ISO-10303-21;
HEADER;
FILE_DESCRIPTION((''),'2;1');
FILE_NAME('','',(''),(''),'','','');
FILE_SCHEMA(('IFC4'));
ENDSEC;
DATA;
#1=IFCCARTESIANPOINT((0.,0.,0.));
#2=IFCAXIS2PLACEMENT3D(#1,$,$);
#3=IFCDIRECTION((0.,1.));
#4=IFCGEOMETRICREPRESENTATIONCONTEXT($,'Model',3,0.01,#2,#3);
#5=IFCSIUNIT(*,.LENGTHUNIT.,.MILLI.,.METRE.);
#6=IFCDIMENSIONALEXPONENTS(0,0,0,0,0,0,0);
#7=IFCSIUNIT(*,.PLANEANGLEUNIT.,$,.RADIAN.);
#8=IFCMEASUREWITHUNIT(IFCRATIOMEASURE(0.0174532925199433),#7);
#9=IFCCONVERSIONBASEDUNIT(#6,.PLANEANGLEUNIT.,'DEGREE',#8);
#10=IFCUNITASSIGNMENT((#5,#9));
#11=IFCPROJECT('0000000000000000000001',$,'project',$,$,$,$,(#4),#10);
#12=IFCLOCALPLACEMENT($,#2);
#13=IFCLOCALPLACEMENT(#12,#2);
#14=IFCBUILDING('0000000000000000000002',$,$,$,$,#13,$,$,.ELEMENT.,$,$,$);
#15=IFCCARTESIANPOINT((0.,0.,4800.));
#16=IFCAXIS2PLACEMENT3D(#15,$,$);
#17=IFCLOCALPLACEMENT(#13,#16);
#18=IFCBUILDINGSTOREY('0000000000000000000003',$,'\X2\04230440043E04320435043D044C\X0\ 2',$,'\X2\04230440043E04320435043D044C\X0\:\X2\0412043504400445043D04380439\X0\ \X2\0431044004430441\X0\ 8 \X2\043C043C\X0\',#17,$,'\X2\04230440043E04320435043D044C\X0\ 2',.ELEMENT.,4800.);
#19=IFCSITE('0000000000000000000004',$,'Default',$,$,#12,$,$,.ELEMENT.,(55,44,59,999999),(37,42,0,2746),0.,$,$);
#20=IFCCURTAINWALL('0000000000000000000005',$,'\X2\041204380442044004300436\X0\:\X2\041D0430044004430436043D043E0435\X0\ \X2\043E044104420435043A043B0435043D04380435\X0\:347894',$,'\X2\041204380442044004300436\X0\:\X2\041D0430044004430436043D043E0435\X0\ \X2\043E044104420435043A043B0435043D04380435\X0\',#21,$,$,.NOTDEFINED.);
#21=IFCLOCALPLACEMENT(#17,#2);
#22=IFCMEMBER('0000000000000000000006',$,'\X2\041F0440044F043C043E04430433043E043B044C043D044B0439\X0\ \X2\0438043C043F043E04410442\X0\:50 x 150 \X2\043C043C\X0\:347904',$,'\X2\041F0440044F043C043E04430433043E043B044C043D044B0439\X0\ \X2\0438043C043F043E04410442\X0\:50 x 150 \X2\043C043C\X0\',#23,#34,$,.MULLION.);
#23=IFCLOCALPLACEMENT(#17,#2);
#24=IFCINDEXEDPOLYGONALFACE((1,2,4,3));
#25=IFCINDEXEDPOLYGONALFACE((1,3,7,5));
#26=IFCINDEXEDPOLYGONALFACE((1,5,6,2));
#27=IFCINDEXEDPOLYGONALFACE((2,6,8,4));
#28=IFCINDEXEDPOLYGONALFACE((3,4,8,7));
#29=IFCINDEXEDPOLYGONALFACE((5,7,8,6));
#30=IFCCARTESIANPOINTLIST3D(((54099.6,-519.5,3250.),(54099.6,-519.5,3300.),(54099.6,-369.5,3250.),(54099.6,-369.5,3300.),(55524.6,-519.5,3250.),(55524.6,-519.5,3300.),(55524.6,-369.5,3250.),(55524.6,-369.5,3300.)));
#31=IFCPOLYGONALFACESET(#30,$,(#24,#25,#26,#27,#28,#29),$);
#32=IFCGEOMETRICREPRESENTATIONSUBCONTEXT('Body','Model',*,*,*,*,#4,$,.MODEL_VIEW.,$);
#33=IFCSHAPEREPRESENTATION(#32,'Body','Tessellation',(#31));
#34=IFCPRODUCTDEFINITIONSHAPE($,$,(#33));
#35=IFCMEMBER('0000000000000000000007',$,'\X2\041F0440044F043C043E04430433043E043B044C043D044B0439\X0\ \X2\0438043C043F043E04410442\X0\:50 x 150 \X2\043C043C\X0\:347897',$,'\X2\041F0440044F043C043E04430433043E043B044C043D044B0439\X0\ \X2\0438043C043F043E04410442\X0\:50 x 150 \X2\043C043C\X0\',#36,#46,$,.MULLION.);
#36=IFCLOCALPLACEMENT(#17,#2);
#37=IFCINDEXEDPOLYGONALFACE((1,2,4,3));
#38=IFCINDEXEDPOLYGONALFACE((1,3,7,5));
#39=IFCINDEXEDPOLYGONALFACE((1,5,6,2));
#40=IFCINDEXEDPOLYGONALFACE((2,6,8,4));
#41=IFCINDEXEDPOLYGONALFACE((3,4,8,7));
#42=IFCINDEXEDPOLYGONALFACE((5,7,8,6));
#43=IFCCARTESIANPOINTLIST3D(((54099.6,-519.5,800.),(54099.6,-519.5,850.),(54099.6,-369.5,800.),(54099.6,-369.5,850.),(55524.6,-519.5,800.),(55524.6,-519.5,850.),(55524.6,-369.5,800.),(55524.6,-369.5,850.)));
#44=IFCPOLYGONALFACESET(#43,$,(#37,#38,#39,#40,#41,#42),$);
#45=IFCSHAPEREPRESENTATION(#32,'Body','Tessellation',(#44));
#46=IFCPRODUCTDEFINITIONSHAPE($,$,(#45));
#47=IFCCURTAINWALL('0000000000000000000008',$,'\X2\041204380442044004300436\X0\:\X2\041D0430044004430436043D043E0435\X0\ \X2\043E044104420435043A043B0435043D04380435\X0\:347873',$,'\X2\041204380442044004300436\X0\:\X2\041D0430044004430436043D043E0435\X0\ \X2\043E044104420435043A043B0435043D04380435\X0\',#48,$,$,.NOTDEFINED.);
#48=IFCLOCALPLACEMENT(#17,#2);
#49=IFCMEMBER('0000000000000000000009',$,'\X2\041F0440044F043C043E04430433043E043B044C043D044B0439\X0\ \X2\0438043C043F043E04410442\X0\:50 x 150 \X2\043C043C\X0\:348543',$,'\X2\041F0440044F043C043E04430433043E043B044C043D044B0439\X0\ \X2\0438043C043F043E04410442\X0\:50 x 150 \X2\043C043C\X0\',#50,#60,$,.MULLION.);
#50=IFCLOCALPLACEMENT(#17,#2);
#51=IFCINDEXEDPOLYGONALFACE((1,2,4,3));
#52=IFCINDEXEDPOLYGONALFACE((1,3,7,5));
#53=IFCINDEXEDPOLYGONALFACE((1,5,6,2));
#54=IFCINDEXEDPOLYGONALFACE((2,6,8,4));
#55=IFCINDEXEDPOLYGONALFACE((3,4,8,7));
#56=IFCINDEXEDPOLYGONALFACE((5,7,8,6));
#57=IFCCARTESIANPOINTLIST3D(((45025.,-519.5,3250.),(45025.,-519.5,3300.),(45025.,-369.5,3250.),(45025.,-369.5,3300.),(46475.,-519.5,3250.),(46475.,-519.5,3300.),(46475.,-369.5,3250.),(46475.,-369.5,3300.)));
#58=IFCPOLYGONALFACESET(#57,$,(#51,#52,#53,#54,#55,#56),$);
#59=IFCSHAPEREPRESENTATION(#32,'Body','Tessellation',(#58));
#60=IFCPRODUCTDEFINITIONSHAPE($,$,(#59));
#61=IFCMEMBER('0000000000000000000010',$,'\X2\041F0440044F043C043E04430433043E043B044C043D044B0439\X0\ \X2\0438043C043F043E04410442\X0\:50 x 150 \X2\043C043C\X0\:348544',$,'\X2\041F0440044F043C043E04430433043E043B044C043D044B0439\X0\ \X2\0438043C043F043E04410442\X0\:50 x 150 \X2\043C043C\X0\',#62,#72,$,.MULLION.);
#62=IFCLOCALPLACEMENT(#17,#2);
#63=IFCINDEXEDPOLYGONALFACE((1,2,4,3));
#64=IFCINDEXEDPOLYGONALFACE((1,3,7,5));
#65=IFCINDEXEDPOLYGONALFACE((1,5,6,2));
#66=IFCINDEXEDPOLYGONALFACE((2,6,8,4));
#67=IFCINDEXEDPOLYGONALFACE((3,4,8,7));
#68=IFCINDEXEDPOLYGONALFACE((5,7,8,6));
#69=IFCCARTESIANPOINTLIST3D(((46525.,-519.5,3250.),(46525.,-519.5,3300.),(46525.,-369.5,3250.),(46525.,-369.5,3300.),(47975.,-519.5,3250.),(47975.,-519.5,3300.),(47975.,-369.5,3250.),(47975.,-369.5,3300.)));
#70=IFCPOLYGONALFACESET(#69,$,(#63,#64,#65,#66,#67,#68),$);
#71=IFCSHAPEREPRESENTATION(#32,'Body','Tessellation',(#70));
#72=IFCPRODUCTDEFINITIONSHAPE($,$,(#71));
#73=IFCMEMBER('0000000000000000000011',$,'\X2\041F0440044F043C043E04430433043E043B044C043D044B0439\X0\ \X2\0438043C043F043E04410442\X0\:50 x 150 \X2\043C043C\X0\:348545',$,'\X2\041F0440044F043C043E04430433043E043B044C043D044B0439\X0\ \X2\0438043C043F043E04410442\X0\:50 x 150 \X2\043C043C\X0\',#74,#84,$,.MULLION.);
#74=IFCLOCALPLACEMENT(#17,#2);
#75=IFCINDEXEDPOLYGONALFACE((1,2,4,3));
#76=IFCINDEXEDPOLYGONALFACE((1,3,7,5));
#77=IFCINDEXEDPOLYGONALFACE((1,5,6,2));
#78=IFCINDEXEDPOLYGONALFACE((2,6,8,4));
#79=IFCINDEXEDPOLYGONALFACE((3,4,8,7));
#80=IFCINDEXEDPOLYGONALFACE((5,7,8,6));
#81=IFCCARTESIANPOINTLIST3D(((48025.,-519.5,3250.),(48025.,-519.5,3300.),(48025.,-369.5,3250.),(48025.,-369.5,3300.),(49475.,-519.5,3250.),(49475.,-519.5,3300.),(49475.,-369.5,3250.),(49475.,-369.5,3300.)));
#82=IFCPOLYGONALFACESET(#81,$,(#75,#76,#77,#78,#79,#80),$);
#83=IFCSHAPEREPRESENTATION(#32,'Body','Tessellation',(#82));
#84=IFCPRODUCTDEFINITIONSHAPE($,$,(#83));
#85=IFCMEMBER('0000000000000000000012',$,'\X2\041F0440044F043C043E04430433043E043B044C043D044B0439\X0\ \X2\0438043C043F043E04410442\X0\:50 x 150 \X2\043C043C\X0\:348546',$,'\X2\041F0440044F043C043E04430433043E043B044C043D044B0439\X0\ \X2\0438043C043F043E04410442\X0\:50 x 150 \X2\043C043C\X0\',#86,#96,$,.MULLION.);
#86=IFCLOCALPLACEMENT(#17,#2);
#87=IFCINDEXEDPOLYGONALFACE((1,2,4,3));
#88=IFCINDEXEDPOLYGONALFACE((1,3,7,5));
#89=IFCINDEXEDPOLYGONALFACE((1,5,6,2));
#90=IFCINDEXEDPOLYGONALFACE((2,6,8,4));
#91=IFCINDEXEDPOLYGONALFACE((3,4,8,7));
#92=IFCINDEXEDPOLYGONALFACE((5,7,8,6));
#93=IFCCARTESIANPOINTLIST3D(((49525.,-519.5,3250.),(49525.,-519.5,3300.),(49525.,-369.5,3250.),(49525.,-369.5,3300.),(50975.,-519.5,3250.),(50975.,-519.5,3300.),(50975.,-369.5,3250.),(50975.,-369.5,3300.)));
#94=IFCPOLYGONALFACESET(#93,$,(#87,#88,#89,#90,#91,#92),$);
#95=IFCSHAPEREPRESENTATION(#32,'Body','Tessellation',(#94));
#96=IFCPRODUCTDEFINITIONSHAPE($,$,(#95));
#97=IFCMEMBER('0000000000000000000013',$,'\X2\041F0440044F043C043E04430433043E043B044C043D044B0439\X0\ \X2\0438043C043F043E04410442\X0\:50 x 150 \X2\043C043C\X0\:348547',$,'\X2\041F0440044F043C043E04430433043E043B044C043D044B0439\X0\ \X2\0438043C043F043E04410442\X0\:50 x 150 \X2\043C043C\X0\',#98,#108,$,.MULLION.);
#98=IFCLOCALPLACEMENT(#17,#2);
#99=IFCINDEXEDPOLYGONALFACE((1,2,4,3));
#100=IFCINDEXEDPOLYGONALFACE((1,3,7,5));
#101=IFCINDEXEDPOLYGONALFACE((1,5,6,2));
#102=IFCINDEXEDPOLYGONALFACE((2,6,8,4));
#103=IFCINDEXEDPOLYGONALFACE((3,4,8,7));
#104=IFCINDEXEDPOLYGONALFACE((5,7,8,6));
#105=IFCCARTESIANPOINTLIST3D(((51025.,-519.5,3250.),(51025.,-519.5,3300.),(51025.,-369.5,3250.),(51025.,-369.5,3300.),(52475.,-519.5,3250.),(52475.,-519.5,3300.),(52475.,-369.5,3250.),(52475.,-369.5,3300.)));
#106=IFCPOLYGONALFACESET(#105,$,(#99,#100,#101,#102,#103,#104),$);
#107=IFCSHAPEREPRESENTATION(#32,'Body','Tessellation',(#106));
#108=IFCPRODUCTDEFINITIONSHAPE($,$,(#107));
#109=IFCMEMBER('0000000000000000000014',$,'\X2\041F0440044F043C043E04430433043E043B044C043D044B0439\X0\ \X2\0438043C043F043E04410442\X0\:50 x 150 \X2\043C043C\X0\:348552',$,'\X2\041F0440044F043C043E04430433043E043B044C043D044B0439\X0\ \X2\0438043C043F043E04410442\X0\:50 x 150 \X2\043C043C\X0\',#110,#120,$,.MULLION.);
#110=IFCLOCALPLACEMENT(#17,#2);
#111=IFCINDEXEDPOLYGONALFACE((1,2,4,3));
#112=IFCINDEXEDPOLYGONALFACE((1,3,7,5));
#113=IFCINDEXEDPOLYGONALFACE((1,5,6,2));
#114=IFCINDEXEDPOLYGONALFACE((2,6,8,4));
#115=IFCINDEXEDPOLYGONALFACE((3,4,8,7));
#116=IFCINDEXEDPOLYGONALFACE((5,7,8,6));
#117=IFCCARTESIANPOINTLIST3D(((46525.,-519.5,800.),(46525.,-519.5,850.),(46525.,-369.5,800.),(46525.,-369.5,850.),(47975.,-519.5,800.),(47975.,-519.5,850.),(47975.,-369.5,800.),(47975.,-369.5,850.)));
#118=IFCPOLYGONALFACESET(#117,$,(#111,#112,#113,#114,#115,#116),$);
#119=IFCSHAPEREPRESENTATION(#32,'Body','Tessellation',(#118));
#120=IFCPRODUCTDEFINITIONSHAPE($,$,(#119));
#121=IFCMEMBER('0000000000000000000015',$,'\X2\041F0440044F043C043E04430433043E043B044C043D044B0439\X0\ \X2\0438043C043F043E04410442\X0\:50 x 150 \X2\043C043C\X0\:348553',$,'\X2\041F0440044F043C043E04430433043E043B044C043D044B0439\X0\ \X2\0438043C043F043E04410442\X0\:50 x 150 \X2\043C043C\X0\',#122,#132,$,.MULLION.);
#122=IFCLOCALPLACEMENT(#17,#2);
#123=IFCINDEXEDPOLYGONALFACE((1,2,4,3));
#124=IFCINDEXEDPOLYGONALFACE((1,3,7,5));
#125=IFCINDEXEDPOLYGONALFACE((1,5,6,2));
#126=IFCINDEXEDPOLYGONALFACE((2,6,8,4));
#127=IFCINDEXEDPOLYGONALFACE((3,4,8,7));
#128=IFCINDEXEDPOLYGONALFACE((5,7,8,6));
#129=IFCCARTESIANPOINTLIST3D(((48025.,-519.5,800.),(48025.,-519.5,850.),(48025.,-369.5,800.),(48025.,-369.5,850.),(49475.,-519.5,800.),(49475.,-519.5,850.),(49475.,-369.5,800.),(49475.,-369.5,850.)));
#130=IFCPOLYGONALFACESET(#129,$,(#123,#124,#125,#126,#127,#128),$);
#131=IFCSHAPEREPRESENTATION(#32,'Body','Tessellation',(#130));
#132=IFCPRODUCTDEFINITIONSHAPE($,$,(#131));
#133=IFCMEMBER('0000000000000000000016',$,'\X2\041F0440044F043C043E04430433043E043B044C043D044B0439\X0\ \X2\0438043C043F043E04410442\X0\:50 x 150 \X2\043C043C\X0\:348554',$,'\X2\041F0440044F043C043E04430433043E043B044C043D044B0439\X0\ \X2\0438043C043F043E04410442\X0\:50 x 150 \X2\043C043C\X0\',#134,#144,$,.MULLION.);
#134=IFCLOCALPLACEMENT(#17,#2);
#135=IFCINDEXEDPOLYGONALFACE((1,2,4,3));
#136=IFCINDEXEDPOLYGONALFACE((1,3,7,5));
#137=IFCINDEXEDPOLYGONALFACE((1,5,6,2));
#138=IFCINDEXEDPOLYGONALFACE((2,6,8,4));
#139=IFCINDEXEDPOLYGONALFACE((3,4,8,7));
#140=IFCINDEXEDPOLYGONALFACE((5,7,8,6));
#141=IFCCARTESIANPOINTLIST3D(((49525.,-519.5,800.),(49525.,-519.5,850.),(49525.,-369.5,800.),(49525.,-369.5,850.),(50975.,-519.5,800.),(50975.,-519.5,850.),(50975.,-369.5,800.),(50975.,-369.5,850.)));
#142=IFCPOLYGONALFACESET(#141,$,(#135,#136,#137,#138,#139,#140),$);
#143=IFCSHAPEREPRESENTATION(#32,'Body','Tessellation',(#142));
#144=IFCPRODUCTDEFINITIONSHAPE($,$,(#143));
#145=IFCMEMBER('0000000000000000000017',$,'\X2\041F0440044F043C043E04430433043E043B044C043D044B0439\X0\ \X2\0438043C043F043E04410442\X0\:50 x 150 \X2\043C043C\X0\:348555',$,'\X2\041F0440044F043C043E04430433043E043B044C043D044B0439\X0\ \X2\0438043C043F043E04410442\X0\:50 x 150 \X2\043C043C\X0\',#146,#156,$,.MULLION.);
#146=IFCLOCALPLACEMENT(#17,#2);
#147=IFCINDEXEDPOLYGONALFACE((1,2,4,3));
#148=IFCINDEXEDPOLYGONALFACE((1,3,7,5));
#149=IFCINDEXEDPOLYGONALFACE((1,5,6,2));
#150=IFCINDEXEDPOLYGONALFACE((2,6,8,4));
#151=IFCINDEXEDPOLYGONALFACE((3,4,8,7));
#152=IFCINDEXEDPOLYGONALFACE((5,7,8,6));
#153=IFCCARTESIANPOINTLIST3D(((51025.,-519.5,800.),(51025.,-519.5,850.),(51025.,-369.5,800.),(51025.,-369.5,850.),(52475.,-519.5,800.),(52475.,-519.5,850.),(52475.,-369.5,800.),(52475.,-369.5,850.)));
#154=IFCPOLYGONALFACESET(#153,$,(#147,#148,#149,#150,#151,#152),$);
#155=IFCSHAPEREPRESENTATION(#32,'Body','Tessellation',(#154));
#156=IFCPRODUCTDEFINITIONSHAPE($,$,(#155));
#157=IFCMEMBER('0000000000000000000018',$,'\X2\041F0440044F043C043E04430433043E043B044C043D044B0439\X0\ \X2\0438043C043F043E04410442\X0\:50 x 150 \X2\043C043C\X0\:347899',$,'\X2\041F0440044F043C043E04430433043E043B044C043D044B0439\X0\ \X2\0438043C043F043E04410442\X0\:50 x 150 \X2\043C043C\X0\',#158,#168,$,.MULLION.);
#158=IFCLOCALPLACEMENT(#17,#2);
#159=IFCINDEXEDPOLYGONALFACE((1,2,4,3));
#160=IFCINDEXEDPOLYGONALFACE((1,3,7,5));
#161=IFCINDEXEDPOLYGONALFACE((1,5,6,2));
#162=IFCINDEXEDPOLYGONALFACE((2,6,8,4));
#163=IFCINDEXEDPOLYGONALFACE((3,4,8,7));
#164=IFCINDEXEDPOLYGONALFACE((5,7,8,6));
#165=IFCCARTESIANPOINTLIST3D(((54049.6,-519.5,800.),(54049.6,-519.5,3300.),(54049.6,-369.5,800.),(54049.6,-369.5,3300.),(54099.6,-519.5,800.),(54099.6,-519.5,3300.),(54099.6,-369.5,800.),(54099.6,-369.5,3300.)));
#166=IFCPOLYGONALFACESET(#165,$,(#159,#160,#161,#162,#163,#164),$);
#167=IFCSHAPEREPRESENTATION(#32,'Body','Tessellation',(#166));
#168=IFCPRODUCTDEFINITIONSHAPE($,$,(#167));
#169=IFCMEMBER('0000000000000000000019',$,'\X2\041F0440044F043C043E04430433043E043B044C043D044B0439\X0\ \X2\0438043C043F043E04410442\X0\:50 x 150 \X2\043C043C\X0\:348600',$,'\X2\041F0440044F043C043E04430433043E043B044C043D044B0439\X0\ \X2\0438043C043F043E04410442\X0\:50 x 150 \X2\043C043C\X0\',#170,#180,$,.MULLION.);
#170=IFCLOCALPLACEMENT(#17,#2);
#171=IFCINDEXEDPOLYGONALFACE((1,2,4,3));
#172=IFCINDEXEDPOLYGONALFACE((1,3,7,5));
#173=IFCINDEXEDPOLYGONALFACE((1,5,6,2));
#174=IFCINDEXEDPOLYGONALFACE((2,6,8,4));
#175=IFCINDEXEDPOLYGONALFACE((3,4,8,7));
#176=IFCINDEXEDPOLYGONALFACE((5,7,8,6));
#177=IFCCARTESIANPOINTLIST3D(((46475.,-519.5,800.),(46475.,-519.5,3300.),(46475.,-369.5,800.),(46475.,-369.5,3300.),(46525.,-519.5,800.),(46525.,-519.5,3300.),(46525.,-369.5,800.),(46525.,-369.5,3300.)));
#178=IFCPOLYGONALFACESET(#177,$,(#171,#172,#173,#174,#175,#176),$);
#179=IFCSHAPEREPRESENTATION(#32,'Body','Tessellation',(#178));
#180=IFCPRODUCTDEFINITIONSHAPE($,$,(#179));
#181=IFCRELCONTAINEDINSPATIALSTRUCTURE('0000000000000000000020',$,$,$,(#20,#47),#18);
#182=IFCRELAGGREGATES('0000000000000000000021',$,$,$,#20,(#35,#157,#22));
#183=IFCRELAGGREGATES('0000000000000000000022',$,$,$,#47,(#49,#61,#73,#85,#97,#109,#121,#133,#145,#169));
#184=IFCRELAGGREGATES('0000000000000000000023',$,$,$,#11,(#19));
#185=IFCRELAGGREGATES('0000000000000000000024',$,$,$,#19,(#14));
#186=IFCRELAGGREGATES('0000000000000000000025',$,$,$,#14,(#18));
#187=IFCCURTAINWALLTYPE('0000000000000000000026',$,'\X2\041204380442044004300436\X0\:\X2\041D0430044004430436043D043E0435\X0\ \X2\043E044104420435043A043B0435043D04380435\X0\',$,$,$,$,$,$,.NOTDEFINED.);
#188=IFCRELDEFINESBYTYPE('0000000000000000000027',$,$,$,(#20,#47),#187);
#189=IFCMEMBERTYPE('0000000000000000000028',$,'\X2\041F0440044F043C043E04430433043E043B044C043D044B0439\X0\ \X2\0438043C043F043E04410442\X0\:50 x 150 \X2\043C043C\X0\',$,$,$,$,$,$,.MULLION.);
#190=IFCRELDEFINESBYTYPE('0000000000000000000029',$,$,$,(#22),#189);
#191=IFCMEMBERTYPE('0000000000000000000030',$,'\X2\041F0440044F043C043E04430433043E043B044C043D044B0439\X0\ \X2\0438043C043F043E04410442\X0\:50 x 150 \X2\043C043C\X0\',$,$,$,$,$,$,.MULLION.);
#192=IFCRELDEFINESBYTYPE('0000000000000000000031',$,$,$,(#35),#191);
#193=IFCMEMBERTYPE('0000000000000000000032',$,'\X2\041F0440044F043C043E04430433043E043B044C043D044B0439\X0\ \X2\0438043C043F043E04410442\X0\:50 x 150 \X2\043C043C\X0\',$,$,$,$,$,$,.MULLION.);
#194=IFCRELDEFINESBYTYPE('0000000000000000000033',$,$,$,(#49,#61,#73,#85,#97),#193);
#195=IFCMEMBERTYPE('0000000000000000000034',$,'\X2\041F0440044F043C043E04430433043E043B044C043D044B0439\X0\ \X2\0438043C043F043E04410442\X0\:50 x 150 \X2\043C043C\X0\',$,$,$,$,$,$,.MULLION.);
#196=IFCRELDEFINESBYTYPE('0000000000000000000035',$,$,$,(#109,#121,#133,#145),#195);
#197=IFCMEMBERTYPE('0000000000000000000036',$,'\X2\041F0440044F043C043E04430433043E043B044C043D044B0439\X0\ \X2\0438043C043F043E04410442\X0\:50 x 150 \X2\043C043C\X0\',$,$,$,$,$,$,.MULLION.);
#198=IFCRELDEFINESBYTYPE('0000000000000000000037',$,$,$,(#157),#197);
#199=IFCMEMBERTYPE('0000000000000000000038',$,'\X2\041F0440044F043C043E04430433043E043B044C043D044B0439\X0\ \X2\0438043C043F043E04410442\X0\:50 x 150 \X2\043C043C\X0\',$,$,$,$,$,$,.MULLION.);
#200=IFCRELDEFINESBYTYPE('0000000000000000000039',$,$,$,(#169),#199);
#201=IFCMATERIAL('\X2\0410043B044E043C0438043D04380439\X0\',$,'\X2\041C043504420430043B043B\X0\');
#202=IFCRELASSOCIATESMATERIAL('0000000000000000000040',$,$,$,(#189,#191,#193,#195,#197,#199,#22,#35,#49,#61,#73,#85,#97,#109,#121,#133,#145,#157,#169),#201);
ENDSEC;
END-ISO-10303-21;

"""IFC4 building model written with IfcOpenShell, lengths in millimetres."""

from ifc_helpers import new_model, entity, si_unit, converted_unit, direction, frame, origin, origin_2d_with_axis, place, context, subcontext, project, spatial, rectangle, extrude, source, transform, mapped, material, material_profile, profile_set, profile_usage, type_object, type_shapes, element, aggregate, save


model = new_model("IFC4")

# Units and contexts
model_context = context("Model", 3, precision=0.01, world=origin(), true_north=direction((0.0, 1.0)))
body_context = subcontext(model_context, "Body", "Model", "MODEL_VIEW")
ifc_project = project(units=[si_unit("LENGTHUNIT", "METRE", prefix="MILLI"), converted_unit("PLANEANGLEUNIT", "DEGREE", entity("IfcRatioMeasure", 0.0174532925199433), si_unit("PLANEANGLEUNIT", "RADIAN"), dimensions=[0, 0, 0, 0, 0, 0, 0])], contexts=[model_context])

# Site, building, storey
site_placement = place(None, origin())
site = spatial("IfcSite", under=ifc_project, at=site_placement, Name="Default", CompositionType="ELEMENT", RefLatitude=(55, 44, 59, 999999), RefLongitude=(37, 42, 0, 2746), RefElevation=0.0)
building_placement = place(site_placement, origin())
building = spatial("IfcBuilding", under=site, at=building_placement, CompositionType="ELEMENT")
storey_placement = place(building_placement, frame((0.0, 0.0, 4800.0)))
storey = spatial("IfcBuildingStorey", under=building, at=storey_placement, Name="Уровень 2", ObjectType="Уровень:Верхний брус 8 мм", LongName="Уровень 2", CompositionType="ELEMENT", Elevation=4800.0)

# Curtain walls, members
curtain_wall_type = type_object("IfcCurtainWallType", Name="Витраж:Наружное остекление", PredefinedType="NOTDEFINED")
curtain_wall_1_placement = place(storey_placement, frame((0.0, 0.0, -4800.0)))
curtain_wall_1 = element("IfcCurtainWall", 1, at=curtain_wall_1_placement, inside=storey, type_object=curtain_wall_type, Name="Витраж:Наружное остекление:347894", ObjectType="Витраж:Наружное остекление", PredefinedType="NOTDEFINED")
ifc_material = material(Name="Алюминий", Category="Металл")
ifc_material_profile = material_profile(ifc_material, rectangle(XDim=150.0, YDim=50.0, at=origin_2d_with_axis()), Name="50 x 150 мм")
ifc_profile_set = profile_set([ifc_material_profile], Name="50 x 150 мм")
ifc_profile_usage_1 = profile_usage(ifc_profile_set)
member_type_1 = type_object("IfcMemberType", Name="Прямоугольный импост:50 x 150 мм", PredefinedType="MULLION", material=ifc_profile_set)
shared_shape_1 = source(origin(), body_context, "Body", "SweptSolid", [
    extrude(rectangle(XDim=150.0, YDim=50.0, at=origin_2d_with_axis()), frame((-25.0, 0.0, -1425.0), z_axis=(0.0, 0.0, 1.0), x_axis=(0.0, -1.0, 0.0)), (0.0, 0.0, 1.0), 1425.0),
])
type_shapes(member_type_1, [shared_shape_1])
member_1_placement = place(storey_placement, frame((55524.6, -444.5, 3300.0), z_axis=(1.0, 0.0, 0.0), x_axis=(0.0, 0.0, 1.0)))
member_1 = element("IfcMember", 2, at=member_1_placement, type_object=member_type_1, material=ifc_profile_usage_1, Name="Прямоугольный импост:50 x 150 мм:347904", ObjectType="Прямоугольный импост:50 x 150 мм", PredefinedType="MULLION", context=body_context, shape_type="MappedRepresentation", body=[
    mapped(shared_shape_1, transform((0.0, 0.0, 0.0), scale=1.0)),
])
ifc_profile_usage_2 = profile_usage(ifc_profile_set)
member_type_2 = type_object("IfcMemberType", Name="Прямоугольный импост:50 x 150 мм", PredefinedType="MULLION", material=ifc_profile_set)
shared_shape_2 = source(origin(), body_context, "Body", "SweptSolid", [
    extrude(rectangle(XDim=150.0, YDim=50.0, at=origin_2d_with_axis()), frame((-25.0, 0.0, -1425.0), z_axis=(0.0, 0.0, 1.0), x_axis=(0.0, -1.0, 0.0)), (0.0, 0.0, 1.0), 1425.0),
])
type_shapes(member_type_2, [shared_shape_2])
member_2_placement = place(storey_placement, frame((54099.6, -444.5, 800.0), z_axis=(-1.0, 0.0, 0.0), x_axis=(0.0, 0.0, -1.0)))
member_2 = element("IfcMember", 3, at=member_2_placement, type_object=member_type_2, material=ifc_profile_usage_2, Name="Прямоугольный импост:50 x 150 мм:347897", ObjectType="Прямоугольный импост:50 x 150 мм", PredefinedType="MULLION", context=body_context, shape_type="MappedRepresentation", body=[
    mapped(shared_shape_2, transform((0.0, 0.0, 0.0), scale=1.0)),
])
curtain_wall_2_placement = place(storey_placement, frame((0.0, 0.0, -4800.0)))
curtain_wall_2 = element("IfcCurtainWall", 4, at=curtain_wall_2_placement, inside=storey, type_object=curtain_wall_type, Name="Витраж:Наружное остекление:347873", ObjectType="Витраж:Наружное остекление", PredefinedType="NOTDEFINED")
ifc_profile_usage_3 = profile_usage(ifc_profile_set)
member_type_3 = type_object("IfcMemberType", Name="Прямоугольный импост:50 x 150 мм", PredefinedType="MULLION", material=ifc_profile_set)
shared_shape_3 = source(origin(), body_context, "Body", "SweptSolid", [
    extrude(rectangle(XDim=150.0, YDim=50.0, at=origin_2d_with_axis()), frame((-25.0, 0.0, -1450.0), z_axis=(0.0, 0.0, 1.0), x_axis=(0.0, -1.0, 0.0)), (0.0, 0.0, 1.0), 1450.0),
])
type_shapes(member_type_3, [shared_shape_3])
member_3_placement = place(storey_placement, frame((46475.0, -444.5, 3300.0), z_axis=(1.0, 0.0, 0.0), x_axis=(0.0, 0.0, 1.0)))
member_3 = element("IfcMember", 5, at=member_3_placement, type_object=member_type_3, material=ifc_profile_usage_3, Name="Прямоугольный импост:50 x 150 мм:348543", ObjectType="Прямоугольный импост:50 x 150 мм", PredefinedType="MULLION", context=body_context, shape_type="MappedRepresentation", body=[
    mapped(shared_shape_3, transform((0.0, 0.0, 0.0), scale=1.0)),
])
ifc_profile_usage_4 = profile_usage(ifc_profile_set)
member_4_placement = place(storey_placement, frame((47975.0, -444.5, 3300.0), z_axis=(1.0, 0.0, 0.0), x_axis=(0.0, 0.0, 1.0)))
member_4 = element("IfcMember", 6, at=member_4_placement, type_object=member_type_3, material=ifc_profile_usage_4, Name="Прямоугольный импост:50 x 150 мм:348544", ObjectType="Прямоугольный импост:50 x 150 мм", PredefinedType="MULLION", context=body_context, shape_type="MappedRepresentation", body=[
    mapped(shared_shape_3, transform((0.0, 0.0, 0.0), scale=1.0)),
])
ifc_profile_usage_5 = profile_usage(ifc_profile_set)
member_5_placement = place(storey_placement, frame((49475.0, -444.5, 3300.0), z_axis=(1.0, 0.0, 0.0), x_axis=(0.0, 0.0, 1.0)))
member_5 = element("IfcMember", 7, at=member_5_placement, type_object=member_type_3, material=ifc_profile_usage_5, Name="Прямоугольный импост:50 x 150 мм:348545", ObjectType="Прямоугольный импост:50 x 150 мм", PredefinedType="MULLION", context=body_context, shape_type="MappedRepresentation", body=[
    mapped(shared_shape_3, transform((0.0, 0.0, 0.0), scale=1.0)),
])
ifc_profile_usage_6 = profile_usage(ifc_profile_set)
member_6_placement = place(storey_placement, frame((50975.0, -444.5, 3300.0), z_axis=(1.0, 0.0, 0.0), x_axis=(0.0, 0.0, 1.0)))
member_6 = element("IfcMember", 8, at=member_6_placement, type_object=member_type_3, material=ifc_profile_usage_6, Name="Прямоугольный импост:50 x 150 мм:348546", ObjectType="Прямоугольный импост:50 x 150 мм", PredefinedType="MULLION", context=body_context, shape_type="MappedRepresentation", body=[
    mapped(shared_shape_3, transform((0.0, 0.0, 0.0), scale=1.0)),
])
ifc_profile_usage_7 = profile_usage(ifc_profile_set)
member_7_placement = place(storey_placement, frame((52475.0, -444.5, 3300.0), z_axis=(1.0, 0.0, 0.0), x_axis=(0.0, 0.0, 1.0)))
member_7 = element("IfcMember", 9, at=member_7_placement, type_object=member_type_3, material=ifc_profile_usage_7, Name="Прямоугольный импост:50 x 150 мм:348547", ObjectType="Прямоугольный импост:50 x 150 мм", PredefinedType="MULLION", context=body_context, shape_type="MappedRepresentation", body=[
    mapped(shared_shape_3, transform((0.0, 0.0, 0.0), scale=1.0)),
])
ifc_profile_usage_8 = profile_usage(ifc_profile_set)
member_type_4 = type_object("IfcMemberType", Name="Прямоугольный импост:50 x 150 мм", PredefinedType="MULLION", material=ifc_profile_set)
shared_shape_4 = source(origin(), body_context, "Body", "SweptSolid", [
    extrude(rectangle(XDim=150.0, YDim=50.0, at=origin_2d_with_axis()), frame((-25.0, 0.0, -1450.0), z_axis=(0.0, 0.0, 1.0), x_axis=(0.0, -1.0, 0.0)), (0.0, 0.0, 1.0), 1450.0),
])
type_shapes(member_type_4, [shared_shape_4])
member_8_placement = place(storey_placement, frame((46525.0, -444.5, 800.0), z_axis=(-1.0, 0.0, 0.0), x_axis=(0.0, 0.0, -1.0)))
member_8 = element("IfcMember", 10, at=member_8_placement, type_object=member_type_4, material=ifc_profile_usage_8, Name="Прямоугольный импост:50 x 150 мм:348552", ObjectType="Прямоугольный импост:50 x 150 мм", PredefinedType="MULLION", context=body_context, shape_type="MappedRepresentation", body=[
    mapped(shared_shape_4, transform((0.0, 0.0, 0.0), scale=1.0)),
])
ifc_profile_usage_9 = profile_usage(ifc_profile_set)
member_9_placement = place(storey_placement, frame((48025.0, -444.5, 800.0), z_axis=(-1.0, 0.0, 0.0), x_axis=(0.0, 0.0, -1.0)))
member_9 = element("IfcMember", 11, at=member_9_placement, type_object=member_type_4, material=ifc_profile_usage_9, Name="Прямоугольный импост:50 x 150 мм:348553", ObjectType="Прямоугольный импост:50 x 150 мм", PredefinedType="MULLION", context=body_context, shape_type="MappedRepresentation", body=[
    mapped(shared_shape_4, transform((0.0, 0.0, 0.0), scale=1.0)),
])
ifc_profile_usage_10 = profile_usage(ifc_profile_set)
member_10_placement = place(storey_placement, frame((49525.0, -444.5, 800.0), z_axis=(-1.0, 0.0, 0.0), x_axis=(0.0, 0.0, -1.0)))
member_10 = element("IfcMember", 12, at=member_10_placement, type_object=member_type_4, material=ifc_profile_usage_10, Name="Прямоугольный импост:50 x 150 мм:348554", ObjectType="Прямоугольный импост:50 x 150 мм", PredefinedType="MULLION", context=body_context, shape_type="MappedRepresentation", body=[
    mapped(shared_shape_4, transform((0.0, 0.0, 0.0), scale=1.0)),
])
ifc_profile_usage_11 = profile_usage(ifc_profile_set)
member_11_placement = place(storey_placement, frame((51025.0, -444.5, 800.0), z_axis=(-1.0, 0.0, 0.0), x_axis=(0.0, 0.0, -1.0)))
member_11 = element("IfcMember", 13, at=member_11_placement, type_object=member_type_4, material=ifc_profile_usage_11, Name="Прямоугольный импост:50 x 150 мм:348555", ObjectType="Прямоугольный импост:50 x 150 мм", PredefinedType="MULLION", context=body_context, shape_type="MappedRepresentation", body=[
    mapped(shared_shape_4, transform((0.0, 0.0, 0.0), scale=1.0)),
])

# Members
ifc_profile_usage_12 = profile_usage(ifc_profile_set)
member_type_5 = type_object("IfcMemberType", Name="Прямоугольный импост:50 x 150 мм", PredefinedType="MULLION", material=ifc_profile_set)
shared_shape_5 = source(origin(), body_context, "Body", "SweptSolid", [
    extrude(rectangle(XDim=150.0, YDim=50.0, at=origin_2d_with_axis()), frame((-25.0, 0.0, -2500.0), z_axis=(0.0, 0.0, 1.0), x_axis=(0.0, -1.0, 0.0)), (0.0, 0.0, 1.0), 2500.0),
])
type_shapes(member_type_5, [shared_shape_5])
member_12_placement = place(storey_placement, frame((54049.6, -444.5, 3300.0), z_axis=(0.0, 0.0, 1.0), x_axis=(-1.0, 0.0, 0.0)))
member_12 = element("IfcMember", 14, at=member_12_placement, type_object=member_type_5, material=ifc_profile_usage_12, Name="Прямоугольный импост:50 x 150 мм:347899", ObjectType="Прямоугольный импост:50 x 150 мм", PredefinedType="MULLION", context=body_context, shape_type="MappedRepresentation", body=[
    mapped(shared_shape_5, transform((0.0, 0.0, 0.0), scale=1.0)),
])
ifc_profile_usage_13 = profile_usage(ifc_profile_set)
member_type_6 = type_object("IfcMemberType", Name="Прямоугольный импост:50 x 150 мм", PredefinedType="MULLION", material=ifc_profile_set)
shared_shape_6 = source(origin(), body_context, "Body", "SweptSolid", [
    extrude(rectangle(XDim=150.0, YDim=50.0, at=origin_2d_with_axis()), frame((0.0, 0.0, -2500.0), z_axis=(0.0, 0.0, 1.0), x_axis=(0.0, -1.0, 0.0)), (0.0, 0.0, 1.0), 2500.0),
])
type_shapes(member_type_6, [shared_shape_6])
member_13_placement = place(storey_placement, frame((46500.0, -444.5, 800.0), z_axis=(0.0, 0.0, -1.0), x_axis=(1.0, 0.0, 0.0)))
member_13 = element("IfcMember", 15, at=member_13_placement, type_object=member_type_6, material=ifc_profile_usage_13, Name="Прямоугольный импост:50 x 150 мм:348600", ObjectType="Прямоугольный импост:50 x 150 мм", PredefinedType="MULLION", context=body_context, shape_type="MappedRepresentation", body=[
    mapped(shared_shape_6, transform((0.0, 0.0, 0.0), scale=1.0)),
])
aggregate(curtain_wall_1, [member_2, member_12, member_1])
aggregate(curtain_wall_2, [member_3, member_4, member_5, member_6, member_7, member_8, member_9, member_10, member_11, member_13])

save(model, "model.ifc")
